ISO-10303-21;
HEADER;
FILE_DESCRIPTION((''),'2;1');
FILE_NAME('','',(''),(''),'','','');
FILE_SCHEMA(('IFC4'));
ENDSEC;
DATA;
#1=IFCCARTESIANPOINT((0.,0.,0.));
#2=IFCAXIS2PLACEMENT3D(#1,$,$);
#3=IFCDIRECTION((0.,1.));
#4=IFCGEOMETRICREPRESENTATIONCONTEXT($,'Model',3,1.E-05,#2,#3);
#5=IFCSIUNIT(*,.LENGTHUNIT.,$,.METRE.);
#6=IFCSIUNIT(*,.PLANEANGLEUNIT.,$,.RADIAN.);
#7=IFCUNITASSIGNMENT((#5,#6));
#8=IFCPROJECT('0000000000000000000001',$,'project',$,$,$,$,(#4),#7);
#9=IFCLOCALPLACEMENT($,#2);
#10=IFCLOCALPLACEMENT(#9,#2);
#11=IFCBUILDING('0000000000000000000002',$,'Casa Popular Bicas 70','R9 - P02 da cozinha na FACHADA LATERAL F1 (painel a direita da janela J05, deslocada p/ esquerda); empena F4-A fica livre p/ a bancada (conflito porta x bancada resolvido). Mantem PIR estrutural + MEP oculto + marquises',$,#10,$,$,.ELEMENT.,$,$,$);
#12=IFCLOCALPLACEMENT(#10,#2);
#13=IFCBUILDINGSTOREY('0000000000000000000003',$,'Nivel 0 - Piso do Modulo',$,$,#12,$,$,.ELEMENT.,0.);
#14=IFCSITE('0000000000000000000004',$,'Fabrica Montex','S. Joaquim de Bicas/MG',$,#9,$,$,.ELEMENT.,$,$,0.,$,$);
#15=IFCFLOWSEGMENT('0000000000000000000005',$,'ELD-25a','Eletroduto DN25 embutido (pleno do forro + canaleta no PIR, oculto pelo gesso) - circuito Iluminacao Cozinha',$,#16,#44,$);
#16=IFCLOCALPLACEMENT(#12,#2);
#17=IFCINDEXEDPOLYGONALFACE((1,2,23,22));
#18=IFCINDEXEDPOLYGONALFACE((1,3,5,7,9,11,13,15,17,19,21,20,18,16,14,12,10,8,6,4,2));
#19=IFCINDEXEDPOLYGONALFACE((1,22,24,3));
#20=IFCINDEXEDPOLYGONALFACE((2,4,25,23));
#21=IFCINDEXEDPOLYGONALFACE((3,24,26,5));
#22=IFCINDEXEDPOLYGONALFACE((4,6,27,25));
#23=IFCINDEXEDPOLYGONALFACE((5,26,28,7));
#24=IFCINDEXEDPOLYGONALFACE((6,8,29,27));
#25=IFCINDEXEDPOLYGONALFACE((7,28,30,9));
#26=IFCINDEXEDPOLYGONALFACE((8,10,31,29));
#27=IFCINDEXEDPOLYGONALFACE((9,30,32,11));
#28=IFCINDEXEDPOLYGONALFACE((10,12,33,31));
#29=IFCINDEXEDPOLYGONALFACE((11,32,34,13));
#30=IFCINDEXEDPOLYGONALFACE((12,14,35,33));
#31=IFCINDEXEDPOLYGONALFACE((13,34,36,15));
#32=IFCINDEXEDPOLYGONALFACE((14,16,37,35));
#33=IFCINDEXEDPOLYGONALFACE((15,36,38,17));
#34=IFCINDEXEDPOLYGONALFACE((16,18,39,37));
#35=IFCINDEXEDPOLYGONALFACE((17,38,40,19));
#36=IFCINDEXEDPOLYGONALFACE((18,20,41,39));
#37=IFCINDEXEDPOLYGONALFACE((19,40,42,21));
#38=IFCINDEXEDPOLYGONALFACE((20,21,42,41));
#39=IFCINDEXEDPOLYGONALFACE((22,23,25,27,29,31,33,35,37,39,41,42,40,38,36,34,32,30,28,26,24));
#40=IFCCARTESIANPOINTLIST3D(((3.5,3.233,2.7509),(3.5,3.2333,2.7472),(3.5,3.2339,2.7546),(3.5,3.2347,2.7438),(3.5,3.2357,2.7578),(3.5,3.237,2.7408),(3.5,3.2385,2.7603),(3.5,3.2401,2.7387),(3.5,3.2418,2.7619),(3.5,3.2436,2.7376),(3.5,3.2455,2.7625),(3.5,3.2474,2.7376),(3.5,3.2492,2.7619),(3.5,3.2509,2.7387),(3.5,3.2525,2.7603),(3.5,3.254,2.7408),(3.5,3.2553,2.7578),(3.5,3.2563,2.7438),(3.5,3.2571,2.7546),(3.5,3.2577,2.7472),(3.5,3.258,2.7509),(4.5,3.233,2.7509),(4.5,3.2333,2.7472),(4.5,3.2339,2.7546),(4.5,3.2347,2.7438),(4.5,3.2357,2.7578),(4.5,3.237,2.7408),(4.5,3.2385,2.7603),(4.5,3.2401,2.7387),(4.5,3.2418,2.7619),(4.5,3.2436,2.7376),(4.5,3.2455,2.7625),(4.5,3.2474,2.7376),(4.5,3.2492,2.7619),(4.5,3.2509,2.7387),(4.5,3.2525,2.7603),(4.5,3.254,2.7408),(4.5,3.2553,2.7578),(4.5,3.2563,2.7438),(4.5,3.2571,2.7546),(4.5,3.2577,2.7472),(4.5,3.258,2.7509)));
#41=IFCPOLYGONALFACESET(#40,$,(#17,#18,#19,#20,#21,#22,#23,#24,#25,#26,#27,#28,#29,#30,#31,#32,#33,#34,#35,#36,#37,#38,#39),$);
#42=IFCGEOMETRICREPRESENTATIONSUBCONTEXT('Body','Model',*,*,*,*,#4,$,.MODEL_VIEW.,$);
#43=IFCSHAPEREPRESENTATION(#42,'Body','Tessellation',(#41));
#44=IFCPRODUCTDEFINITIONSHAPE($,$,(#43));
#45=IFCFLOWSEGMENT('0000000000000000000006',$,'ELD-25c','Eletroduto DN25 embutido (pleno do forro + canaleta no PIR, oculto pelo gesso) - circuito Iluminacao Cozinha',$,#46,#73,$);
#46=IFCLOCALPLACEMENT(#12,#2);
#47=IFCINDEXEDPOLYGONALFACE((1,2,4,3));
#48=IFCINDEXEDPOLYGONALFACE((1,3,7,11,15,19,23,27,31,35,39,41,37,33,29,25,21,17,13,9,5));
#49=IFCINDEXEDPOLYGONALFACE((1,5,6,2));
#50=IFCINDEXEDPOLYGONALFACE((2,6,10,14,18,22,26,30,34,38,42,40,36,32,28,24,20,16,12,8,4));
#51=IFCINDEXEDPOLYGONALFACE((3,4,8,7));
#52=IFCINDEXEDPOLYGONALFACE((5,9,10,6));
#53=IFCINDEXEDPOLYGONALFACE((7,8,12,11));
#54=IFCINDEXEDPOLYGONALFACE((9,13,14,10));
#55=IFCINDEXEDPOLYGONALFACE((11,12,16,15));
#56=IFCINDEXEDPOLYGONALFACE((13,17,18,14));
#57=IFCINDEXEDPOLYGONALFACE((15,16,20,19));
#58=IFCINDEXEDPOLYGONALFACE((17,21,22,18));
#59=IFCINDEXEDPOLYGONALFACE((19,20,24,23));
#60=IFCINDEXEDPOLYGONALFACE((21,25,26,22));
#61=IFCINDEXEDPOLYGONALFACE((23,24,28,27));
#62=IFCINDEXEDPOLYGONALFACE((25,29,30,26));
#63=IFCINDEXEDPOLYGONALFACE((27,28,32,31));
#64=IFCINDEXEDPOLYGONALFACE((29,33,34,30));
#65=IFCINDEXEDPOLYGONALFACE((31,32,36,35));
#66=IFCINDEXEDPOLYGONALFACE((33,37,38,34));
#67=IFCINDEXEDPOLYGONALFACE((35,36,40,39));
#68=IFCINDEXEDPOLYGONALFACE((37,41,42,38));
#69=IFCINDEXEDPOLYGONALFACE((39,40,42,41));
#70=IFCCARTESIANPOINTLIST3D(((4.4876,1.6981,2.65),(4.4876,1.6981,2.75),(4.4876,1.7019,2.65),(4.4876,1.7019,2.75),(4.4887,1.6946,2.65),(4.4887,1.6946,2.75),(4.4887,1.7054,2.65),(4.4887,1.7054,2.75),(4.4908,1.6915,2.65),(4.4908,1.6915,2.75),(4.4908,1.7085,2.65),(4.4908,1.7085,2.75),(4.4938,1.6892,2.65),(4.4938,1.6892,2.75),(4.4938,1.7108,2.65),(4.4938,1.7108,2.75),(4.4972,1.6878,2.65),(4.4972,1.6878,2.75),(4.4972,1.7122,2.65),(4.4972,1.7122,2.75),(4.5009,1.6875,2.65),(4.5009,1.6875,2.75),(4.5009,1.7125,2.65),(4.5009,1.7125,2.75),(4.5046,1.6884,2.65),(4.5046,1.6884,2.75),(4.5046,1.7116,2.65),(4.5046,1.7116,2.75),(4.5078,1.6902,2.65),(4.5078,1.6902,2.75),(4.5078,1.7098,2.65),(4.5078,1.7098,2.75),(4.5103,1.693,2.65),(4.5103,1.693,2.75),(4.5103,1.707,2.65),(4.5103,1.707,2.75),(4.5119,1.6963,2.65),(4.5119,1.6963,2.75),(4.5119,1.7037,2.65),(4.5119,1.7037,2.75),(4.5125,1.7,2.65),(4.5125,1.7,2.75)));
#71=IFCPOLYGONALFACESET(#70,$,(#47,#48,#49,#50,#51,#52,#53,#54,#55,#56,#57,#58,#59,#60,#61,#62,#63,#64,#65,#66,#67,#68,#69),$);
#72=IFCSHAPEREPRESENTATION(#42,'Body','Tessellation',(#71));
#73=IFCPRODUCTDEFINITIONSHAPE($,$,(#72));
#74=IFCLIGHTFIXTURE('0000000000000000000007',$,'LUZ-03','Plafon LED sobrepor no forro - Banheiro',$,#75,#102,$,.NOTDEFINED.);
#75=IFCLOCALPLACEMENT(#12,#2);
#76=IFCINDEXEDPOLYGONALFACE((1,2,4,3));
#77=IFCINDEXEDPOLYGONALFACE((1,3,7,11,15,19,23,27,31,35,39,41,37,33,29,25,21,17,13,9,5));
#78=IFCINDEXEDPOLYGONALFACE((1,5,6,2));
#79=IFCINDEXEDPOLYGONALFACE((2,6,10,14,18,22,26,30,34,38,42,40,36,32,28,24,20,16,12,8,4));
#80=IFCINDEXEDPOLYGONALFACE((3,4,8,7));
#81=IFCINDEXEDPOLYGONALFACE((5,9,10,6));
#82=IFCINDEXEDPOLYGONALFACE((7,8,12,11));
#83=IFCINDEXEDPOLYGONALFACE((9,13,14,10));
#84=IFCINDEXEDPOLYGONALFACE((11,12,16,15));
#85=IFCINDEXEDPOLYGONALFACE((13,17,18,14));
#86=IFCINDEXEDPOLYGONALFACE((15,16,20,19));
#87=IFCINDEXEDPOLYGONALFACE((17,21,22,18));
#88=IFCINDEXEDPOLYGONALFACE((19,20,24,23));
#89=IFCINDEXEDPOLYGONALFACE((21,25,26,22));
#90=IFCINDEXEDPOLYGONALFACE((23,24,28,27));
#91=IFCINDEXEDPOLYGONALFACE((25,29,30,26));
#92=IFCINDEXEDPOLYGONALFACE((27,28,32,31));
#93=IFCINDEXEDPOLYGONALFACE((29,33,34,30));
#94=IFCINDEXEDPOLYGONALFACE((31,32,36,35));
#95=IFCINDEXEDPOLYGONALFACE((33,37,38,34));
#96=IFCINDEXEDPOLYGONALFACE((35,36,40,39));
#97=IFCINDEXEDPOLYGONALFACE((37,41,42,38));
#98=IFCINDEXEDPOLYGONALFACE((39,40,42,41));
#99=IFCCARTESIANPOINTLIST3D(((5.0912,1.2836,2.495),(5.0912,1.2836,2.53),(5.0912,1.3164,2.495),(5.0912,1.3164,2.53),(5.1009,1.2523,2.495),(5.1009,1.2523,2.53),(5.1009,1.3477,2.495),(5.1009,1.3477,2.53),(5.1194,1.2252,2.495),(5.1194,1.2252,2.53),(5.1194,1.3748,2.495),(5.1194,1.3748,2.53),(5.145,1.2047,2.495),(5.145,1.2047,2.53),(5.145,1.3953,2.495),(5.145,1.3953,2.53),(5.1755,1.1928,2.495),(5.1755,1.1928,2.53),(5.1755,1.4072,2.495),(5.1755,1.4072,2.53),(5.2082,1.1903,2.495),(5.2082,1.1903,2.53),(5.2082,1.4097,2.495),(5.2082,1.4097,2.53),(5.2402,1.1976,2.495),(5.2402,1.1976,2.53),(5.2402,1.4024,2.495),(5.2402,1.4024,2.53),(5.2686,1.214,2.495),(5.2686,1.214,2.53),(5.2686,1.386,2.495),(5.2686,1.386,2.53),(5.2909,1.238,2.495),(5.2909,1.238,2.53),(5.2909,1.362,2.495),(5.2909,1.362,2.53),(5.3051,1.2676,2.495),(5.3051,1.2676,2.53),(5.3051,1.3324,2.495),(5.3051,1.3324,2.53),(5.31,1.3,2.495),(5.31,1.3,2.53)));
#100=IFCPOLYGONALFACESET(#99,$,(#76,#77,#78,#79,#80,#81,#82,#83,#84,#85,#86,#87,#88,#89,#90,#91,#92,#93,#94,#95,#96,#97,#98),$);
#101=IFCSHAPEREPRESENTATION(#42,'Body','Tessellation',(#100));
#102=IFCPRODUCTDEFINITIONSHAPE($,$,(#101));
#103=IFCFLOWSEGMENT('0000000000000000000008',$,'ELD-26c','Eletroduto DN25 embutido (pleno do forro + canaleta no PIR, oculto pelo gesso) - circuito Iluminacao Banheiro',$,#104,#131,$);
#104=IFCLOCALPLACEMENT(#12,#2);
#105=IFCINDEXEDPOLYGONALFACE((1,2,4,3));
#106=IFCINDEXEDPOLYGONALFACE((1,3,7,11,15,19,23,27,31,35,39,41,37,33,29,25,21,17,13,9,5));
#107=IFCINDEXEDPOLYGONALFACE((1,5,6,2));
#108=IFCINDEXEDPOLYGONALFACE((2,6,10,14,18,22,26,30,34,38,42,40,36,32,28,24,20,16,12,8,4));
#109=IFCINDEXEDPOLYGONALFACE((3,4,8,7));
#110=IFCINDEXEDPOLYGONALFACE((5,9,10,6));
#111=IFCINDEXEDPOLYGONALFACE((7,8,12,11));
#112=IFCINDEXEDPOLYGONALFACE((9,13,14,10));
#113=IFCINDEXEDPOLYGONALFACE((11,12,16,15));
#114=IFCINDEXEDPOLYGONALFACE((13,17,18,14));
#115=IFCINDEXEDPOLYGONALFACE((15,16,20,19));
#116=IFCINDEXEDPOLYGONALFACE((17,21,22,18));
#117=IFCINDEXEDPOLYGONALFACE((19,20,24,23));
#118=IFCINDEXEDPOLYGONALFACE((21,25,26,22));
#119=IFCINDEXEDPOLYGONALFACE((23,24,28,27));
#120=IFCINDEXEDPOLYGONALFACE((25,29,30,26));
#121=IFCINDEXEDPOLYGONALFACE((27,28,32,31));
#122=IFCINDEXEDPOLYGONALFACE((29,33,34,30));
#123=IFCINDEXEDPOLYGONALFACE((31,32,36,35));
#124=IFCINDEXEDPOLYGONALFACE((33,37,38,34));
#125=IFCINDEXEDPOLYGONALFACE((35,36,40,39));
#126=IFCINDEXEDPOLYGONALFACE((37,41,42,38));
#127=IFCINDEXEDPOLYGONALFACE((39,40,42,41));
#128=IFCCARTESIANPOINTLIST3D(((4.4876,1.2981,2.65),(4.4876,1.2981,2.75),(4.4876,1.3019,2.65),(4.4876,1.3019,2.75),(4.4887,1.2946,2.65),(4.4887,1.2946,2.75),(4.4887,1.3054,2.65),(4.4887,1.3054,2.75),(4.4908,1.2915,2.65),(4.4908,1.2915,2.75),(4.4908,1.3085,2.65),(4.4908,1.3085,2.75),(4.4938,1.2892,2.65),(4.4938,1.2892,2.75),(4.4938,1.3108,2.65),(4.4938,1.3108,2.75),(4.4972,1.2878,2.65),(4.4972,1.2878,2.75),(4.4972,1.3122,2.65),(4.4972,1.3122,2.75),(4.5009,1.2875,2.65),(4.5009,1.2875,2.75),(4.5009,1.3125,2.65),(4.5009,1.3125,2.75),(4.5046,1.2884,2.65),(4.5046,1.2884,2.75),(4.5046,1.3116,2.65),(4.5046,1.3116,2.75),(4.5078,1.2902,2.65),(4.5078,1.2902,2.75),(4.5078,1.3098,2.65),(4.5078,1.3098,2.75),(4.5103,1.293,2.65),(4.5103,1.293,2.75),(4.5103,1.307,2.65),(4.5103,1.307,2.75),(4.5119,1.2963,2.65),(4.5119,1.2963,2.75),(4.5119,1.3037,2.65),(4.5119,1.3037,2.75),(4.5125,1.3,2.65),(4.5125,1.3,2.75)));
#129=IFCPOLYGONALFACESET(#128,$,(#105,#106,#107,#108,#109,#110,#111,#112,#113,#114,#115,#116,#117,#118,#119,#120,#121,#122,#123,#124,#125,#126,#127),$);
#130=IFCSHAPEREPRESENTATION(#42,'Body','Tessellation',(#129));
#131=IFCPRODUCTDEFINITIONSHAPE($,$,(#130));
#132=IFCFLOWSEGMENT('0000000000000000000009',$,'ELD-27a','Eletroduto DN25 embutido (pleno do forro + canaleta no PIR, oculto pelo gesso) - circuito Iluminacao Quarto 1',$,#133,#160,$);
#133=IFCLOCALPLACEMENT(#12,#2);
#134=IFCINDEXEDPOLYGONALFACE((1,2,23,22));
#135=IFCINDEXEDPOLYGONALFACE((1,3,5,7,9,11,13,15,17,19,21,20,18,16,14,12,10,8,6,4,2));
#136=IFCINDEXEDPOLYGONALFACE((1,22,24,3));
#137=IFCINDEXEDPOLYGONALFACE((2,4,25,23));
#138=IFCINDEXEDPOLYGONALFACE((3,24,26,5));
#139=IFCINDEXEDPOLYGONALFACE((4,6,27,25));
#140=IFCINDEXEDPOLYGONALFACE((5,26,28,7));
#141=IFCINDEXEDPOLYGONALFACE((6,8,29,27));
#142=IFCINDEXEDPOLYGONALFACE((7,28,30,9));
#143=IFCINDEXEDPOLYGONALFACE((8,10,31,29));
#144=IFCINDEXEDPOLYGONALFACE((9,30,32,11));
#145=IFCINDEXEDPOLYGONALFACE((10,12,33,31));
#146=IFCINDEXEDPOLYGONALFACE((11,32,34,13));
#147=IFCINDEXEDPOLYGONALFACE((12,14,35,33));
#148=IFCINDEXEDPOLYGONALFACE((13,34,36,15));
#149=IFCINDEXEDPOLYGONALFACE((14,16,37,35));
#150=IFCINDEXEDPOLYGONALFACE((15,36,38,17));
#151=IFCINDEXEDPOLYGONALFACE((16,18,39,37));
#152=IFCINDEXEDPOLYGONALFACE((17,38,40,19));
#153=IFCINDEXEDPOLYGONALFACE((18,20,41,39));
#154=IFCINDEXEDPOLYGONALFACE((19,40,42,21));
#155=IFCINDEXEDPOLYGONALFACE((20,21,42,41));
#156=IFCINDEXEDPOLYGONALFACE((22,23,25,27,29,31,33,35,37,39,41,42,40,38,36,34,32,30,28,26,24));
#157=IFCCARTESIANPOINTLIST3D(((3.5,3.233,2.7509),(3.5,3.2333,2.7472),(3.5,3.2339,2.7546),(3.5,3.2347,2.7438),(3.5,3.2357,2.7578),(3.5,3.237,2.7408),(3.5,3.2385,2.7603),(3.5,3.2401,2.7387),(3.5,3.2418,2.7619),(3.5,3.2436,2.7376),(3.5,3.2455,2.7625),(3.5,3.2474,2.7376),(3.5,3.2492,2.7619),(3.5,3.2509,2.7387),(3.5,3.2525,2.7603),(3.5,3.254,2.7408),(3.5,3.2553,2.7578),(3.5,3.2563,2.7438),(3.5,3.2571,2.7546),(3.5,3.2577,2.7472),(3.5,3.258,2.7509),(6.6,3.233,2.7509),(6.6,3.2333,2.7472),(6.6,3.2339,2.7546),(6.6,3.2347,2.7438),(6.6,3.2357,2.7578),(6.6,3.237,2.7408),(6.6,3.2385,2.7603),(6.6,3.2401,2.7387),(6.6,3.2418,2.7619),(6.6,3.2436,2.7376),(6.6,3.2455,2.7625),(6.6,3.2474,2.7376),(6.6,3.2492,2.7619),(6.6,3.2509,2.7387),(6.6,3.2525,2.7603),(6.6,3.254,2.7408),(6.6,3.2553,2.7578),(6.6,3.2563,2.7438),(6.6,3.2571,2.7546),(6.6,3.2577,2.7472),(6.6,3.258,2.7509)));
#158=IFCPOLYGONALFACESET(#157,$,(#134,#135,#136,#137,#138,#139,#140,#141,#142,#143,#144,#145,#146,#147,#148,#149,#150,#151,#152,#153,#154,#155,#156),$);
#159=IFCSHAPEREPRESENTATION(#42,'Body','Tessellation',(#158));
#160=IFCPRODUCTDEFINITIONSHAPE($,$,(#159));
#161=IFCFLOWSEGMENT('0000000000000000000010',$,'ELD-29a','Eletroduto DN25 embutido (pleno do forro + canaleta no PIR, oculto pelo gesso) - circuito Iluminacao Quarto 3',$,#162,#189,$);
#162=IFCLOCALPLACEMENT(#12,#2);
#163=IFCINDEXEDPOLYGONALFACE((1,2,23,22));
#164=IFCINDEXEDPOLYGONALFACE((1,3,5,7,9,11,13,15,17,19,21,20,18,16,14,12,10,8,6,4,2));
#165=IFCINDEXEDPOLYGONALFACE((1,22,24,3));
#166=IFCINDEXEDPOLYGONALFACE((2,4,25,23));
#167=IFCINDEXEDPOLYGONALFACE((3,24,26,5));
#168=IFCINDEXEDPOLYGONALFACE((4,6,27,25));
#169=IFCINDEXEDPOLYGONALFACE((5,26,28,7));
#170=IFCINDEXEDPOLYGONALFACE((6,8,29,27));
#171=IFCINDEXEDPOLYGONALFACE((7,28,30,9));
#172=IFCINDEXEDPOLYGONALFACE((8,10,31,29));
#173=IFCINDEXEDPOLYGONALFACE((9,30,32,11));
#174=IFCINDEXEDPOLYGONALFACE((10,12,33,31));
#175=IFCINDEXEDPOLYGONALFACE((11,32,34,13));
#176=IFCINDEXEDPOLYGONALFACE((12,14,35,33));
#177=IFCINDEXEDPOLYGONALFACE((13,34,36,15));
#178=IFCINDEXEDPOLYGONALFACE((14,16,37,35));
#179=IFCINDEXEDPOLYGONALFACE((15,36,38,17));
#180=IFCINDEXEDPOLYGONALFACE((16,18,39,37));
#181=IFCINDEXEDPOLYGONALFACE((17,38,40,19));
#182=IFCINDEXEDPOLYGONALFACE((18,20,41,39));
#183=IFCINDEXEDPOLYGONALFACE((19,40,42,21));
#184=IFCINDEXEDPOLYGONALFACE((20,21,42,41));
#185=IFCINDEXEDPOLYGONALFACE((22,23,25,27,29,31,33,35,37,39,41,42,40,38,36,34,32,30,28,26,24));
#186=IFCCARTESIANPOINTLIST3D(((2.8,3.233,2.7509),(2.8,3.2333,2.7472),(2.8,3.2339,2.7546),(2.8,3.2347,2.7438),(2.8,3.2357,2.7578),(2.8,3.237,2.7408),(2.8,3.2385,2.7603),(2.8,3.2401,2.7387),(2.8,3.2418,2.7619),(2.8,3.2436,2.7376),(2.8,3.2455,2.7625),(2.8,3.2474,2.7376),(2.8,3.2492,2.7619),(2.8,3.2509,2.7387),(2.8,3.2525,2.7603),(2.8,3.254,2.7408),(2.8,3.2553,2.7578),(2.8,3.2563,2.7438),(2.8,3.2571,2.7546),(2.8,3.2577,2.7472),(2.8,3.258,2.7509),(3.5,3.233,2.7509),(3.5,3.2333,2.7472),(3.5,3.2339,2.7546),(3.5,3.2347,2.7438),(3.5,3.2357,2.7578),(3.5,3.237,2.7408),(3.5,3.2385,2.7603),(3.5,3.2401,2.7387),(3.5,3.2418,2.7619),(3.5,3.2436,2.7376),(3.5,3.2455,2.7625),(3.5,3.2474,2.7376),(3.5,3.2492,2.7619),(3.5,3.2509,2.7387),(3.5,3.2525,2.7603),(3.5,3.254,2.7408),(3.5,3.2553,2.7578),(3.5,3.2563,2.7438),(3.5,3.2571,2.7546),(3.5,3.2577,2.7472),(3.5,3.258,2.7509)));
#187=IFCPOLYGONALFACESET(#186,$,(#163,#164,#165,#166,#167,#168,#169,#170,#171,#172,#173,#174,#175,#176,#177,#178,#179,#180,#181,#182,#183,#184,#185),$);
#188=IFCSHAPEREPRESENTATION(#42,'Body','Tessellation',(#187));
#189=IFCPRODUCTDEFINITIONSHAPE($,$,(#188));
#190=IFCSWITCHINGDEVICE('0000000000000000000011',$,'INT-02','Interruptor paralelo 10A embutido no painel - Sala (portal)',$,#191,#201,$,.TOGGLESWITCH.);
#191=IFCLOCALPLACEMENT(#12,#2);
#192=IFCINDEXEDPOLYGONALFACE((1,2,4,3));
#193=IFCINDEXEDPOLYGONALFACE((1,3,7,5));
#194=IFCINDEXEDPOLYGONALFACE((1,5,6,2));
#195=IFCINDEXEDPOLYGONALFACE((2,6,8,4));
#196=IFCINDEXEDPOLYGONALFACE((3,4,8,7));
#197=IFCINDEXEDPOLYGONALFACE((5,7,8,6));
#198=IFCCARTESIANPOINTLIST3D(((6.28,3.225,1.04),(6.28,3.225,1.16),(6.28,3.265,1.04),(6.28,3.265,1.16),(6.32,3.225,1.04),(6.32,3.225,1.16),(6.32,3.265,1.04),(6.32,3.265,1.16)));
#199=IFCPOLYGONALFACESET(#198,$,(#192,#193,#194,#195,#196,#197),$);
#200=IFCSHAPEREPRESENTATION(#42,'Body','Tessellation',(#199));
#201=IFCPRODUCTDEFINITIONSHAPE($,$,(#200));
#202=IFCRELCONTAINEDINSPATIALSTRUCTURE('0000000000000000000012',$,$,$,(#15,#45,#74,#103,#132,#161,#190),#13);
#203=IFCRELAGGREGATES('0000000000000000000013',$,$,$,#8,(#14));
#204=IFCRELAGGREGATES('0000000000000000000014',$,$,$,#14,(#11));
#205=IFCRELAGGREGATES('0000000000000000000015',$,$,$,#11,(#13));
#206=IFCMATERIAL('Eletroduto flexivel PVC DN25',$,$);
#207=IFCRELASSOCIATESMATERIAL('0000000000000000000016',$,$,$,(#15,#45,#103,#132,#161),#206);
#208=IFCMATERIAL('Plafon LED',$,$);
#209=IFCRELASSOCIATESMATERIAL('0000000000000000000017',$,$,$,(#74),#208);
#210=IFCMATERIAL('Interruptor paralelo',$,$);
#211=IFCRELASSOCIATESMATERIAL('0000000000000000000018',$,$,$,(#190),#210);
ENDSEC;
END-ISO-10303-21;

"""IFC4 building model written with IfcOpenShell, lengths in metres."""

from ifc_helpers import new_model, si_unit, direction, frame, frame_2d, origin, origin_2d, place, context, subcontext, project, spatial, rectangle, circle, extrude, material, element, save


model = new_model("IFC4")

# Units and contexts
model_context = context("Model", 3, precision=1e-05, world=origin(), true_north=direction((0.0, 1.0)))
body_context = subcontext(model_context, "Body", "Model", "MODEL_VIEW")
ifc_project = project(units=[si_unit("LENGTHUNIT", "METRE"), si_unit("PLANEANGLEUNIT", "RADIAN")], contexts=[model_context])

# Site, building, storey
site_placement = place(None, origin())
site = spatial("IfcSite", under=ifc_project, at=site_placement, Name="Fabrica Montex", Description="S. Joaquim de Bicas/MG", CompositionType="ELEMENT", RefElevation=0.0)
building_placement = place(site_placement, origin())
building = spatial("IfcBuilding", under=site, at=building_placement, Name="Casa Popular Bicas 70", Description="R9 - P02 da cozinha na FACHADA LATERAL F1 (painel a direita da janela J05, deslocada p/ esquerda); empena F4-A fica livre p/ a bancada (conflito porta x bancada resolvido). Mantem PIR estrutural + MEP oculto + marquises", CompositionType="ELEMENT")
storey_placement = place(building_placement, origin())
storey = spatial("IfcBuildingStorey", under=building, at=storey_placement, Name="Nivel 0 - Piso do Modulo", CompositionType="ELEMENT", Elevation=0.0)

# Shared definitions
ifc_material_1 = material(Name="Eletroduto flexivel PVC DN25")

# Flow segments
flow_segment_1_placement = place(storey_placement, frame((3.5, 3.2455, 2.75), z_axis=(1.0, 0.0, 0.0), x_axis=(0.0, 0.0, 1.0)))
element("IfcFlowSegment", 1, at=flow_segment_1_placement, inside=storey, material=ifc_material_1, Name="ELD-25a", Description="Eletroduto DN25 embutido (pleno do forro + canaleta no PIR, oculto pelo gesso) - circuito Iluminacao Cozinha", context=body_context, shape_type="SweptSolid", body=[
    extrude(circle(Radius=0.0125, at=origin_2d()), origin(), (0.0, 0.0, 1.0), 1.0),
])
flow_segment_2_placement = place(storey_placement, frame((4.5, 1.7, 2.75), z_axis=(0.0, 0.0, -1.0), x_axis=(1.0, 0.0, 0.0)))
element("IfcFlowSegment", 2, at=flow_segment_2_placement, inside=storey, material=ifc_material_1, Name="ELD-25c", Description="Eletroduto DN25 embutido (pleno do forro + canaleta no PIR, oculto pelo gesso) - circuito Iluminacao Cozinha", context=body_context, shape_type="SweptSolid", body=[
    extrude(circle(Radius=0.0125, at=origin_2d()), origin(), (0.0, 0.0, 1.0), 0.1),
])

# Light fixture
ifc_material_2 = material(Name="Plafon LED")
light_fixture_placement = place(storey_placement, frame((5.2, 1.3, 2.495)))
element("IfcLightFixture", 3, at=light_fixture_placement, inside=storey, material=ifc_material_2, Name="LUZ-03", Description="Plafon LED sobrepor no forro - Banheiro", PredefinedType="NOTDEFINED", context=body_context, shape_type="SweptSolid", body=[
    extrude(circle(Radius=0.11, at=origin_2d()), origin(), (0.0, 0.0, 1.0), 0.035),
])

# Flow segments
flow_segment_3_placement = place(storey_placement, frame((4.5, 1.3, 2.75), z_axis=(0.0, 0.0, -1.0), x_axis=(1.0, 0.0, 0.0)))
element("IfcFlowSegment", 4, at=flow_segment_3_placement, inside=storey, material=ifc_material_1, Name="ELD-26c", Description="Eletroduto DN25 embutido (pleno do forro + canaleta no PIR, oculto pelo gesso) - circuito Iluminacao Banheiro", context=body_context, shape_type="SweptSolid", body=[
    extrude(circle(Radius=0.0125, at=origin_2d()), origin(), (0.0, 0.0, 1.0), 0.1),
])
for number, where, z_axis, x_axis, name in (
    (5, (3.5, 3.2455, 2.75), (1.0, 0.0, 0.0), (0.0, 0.0, 1.0), "ELD-27a"),
):
    element("IfcFlowSegment", number, at=place(storey_placement, frame(where, z_axis=z_axis, x_axis=x_axis)), inside=storey, material=ifc_material_1, Name=name, Description="Eletroduto DN25 embutido (pleno do forro + canaleta no PIR, oculto pelo gesso) - circuito Iluminacao Quarto 1", context=body_context, shape_type="SweptSolid", body=[
        extrude(circle(Radius=0.0125, at=origin_2d()), origin(), (0.0, 0.0, 1.0), 3.1),
    ])
flow_segment_4_placement = place(storey_placement, frame((3.5, 3.2455, 2.75), z_axis=(-1.0, 0.0, 0.0), x_axis=(0.0, 0.0, 1.0)))
element("IfcFlowSegment", 6, at=flow_segment_4_placement, inside=storey, material=ifc_material_1, Name="ELD-29a", Description="Eletroduto DN25 embutido (pleno do forro + canaleta no PIR, oculto pelo gesso) - circuito Iluminacao Quarto 3", context=body_context, shape_type="SweptSolid", body=[
    extrude(circle(Radius=0.0125, at=origin_2d()), origin(), (0.0, 0.0, 1.0), 0.7),
])

# Switching device
ifc_material_3 = material(Name="Interruptor paralelo")
switching_device_1_placement = place(storey_placement, frame((6.28, 3.225, 1.04)))
element("IfcSwitchingDevice", 7, at=switching_device_1_placement, inside=storey, material=ifc_material_3, Name="INT-02", Description="Interruptor paralelo 10A embutido no painel - Sala (portal)", PredefinedType="TOGGLESWITCH", context=body_context, shape_type="SweptSolid", body=[
    extrude(rectangle(XDim=0.04, YDim=0.04, at=frame_2d((0.02, 0.02))), origin(), (0.0, 0.0, 1.0), 0.12),
])

save(model, "model.ifc")
